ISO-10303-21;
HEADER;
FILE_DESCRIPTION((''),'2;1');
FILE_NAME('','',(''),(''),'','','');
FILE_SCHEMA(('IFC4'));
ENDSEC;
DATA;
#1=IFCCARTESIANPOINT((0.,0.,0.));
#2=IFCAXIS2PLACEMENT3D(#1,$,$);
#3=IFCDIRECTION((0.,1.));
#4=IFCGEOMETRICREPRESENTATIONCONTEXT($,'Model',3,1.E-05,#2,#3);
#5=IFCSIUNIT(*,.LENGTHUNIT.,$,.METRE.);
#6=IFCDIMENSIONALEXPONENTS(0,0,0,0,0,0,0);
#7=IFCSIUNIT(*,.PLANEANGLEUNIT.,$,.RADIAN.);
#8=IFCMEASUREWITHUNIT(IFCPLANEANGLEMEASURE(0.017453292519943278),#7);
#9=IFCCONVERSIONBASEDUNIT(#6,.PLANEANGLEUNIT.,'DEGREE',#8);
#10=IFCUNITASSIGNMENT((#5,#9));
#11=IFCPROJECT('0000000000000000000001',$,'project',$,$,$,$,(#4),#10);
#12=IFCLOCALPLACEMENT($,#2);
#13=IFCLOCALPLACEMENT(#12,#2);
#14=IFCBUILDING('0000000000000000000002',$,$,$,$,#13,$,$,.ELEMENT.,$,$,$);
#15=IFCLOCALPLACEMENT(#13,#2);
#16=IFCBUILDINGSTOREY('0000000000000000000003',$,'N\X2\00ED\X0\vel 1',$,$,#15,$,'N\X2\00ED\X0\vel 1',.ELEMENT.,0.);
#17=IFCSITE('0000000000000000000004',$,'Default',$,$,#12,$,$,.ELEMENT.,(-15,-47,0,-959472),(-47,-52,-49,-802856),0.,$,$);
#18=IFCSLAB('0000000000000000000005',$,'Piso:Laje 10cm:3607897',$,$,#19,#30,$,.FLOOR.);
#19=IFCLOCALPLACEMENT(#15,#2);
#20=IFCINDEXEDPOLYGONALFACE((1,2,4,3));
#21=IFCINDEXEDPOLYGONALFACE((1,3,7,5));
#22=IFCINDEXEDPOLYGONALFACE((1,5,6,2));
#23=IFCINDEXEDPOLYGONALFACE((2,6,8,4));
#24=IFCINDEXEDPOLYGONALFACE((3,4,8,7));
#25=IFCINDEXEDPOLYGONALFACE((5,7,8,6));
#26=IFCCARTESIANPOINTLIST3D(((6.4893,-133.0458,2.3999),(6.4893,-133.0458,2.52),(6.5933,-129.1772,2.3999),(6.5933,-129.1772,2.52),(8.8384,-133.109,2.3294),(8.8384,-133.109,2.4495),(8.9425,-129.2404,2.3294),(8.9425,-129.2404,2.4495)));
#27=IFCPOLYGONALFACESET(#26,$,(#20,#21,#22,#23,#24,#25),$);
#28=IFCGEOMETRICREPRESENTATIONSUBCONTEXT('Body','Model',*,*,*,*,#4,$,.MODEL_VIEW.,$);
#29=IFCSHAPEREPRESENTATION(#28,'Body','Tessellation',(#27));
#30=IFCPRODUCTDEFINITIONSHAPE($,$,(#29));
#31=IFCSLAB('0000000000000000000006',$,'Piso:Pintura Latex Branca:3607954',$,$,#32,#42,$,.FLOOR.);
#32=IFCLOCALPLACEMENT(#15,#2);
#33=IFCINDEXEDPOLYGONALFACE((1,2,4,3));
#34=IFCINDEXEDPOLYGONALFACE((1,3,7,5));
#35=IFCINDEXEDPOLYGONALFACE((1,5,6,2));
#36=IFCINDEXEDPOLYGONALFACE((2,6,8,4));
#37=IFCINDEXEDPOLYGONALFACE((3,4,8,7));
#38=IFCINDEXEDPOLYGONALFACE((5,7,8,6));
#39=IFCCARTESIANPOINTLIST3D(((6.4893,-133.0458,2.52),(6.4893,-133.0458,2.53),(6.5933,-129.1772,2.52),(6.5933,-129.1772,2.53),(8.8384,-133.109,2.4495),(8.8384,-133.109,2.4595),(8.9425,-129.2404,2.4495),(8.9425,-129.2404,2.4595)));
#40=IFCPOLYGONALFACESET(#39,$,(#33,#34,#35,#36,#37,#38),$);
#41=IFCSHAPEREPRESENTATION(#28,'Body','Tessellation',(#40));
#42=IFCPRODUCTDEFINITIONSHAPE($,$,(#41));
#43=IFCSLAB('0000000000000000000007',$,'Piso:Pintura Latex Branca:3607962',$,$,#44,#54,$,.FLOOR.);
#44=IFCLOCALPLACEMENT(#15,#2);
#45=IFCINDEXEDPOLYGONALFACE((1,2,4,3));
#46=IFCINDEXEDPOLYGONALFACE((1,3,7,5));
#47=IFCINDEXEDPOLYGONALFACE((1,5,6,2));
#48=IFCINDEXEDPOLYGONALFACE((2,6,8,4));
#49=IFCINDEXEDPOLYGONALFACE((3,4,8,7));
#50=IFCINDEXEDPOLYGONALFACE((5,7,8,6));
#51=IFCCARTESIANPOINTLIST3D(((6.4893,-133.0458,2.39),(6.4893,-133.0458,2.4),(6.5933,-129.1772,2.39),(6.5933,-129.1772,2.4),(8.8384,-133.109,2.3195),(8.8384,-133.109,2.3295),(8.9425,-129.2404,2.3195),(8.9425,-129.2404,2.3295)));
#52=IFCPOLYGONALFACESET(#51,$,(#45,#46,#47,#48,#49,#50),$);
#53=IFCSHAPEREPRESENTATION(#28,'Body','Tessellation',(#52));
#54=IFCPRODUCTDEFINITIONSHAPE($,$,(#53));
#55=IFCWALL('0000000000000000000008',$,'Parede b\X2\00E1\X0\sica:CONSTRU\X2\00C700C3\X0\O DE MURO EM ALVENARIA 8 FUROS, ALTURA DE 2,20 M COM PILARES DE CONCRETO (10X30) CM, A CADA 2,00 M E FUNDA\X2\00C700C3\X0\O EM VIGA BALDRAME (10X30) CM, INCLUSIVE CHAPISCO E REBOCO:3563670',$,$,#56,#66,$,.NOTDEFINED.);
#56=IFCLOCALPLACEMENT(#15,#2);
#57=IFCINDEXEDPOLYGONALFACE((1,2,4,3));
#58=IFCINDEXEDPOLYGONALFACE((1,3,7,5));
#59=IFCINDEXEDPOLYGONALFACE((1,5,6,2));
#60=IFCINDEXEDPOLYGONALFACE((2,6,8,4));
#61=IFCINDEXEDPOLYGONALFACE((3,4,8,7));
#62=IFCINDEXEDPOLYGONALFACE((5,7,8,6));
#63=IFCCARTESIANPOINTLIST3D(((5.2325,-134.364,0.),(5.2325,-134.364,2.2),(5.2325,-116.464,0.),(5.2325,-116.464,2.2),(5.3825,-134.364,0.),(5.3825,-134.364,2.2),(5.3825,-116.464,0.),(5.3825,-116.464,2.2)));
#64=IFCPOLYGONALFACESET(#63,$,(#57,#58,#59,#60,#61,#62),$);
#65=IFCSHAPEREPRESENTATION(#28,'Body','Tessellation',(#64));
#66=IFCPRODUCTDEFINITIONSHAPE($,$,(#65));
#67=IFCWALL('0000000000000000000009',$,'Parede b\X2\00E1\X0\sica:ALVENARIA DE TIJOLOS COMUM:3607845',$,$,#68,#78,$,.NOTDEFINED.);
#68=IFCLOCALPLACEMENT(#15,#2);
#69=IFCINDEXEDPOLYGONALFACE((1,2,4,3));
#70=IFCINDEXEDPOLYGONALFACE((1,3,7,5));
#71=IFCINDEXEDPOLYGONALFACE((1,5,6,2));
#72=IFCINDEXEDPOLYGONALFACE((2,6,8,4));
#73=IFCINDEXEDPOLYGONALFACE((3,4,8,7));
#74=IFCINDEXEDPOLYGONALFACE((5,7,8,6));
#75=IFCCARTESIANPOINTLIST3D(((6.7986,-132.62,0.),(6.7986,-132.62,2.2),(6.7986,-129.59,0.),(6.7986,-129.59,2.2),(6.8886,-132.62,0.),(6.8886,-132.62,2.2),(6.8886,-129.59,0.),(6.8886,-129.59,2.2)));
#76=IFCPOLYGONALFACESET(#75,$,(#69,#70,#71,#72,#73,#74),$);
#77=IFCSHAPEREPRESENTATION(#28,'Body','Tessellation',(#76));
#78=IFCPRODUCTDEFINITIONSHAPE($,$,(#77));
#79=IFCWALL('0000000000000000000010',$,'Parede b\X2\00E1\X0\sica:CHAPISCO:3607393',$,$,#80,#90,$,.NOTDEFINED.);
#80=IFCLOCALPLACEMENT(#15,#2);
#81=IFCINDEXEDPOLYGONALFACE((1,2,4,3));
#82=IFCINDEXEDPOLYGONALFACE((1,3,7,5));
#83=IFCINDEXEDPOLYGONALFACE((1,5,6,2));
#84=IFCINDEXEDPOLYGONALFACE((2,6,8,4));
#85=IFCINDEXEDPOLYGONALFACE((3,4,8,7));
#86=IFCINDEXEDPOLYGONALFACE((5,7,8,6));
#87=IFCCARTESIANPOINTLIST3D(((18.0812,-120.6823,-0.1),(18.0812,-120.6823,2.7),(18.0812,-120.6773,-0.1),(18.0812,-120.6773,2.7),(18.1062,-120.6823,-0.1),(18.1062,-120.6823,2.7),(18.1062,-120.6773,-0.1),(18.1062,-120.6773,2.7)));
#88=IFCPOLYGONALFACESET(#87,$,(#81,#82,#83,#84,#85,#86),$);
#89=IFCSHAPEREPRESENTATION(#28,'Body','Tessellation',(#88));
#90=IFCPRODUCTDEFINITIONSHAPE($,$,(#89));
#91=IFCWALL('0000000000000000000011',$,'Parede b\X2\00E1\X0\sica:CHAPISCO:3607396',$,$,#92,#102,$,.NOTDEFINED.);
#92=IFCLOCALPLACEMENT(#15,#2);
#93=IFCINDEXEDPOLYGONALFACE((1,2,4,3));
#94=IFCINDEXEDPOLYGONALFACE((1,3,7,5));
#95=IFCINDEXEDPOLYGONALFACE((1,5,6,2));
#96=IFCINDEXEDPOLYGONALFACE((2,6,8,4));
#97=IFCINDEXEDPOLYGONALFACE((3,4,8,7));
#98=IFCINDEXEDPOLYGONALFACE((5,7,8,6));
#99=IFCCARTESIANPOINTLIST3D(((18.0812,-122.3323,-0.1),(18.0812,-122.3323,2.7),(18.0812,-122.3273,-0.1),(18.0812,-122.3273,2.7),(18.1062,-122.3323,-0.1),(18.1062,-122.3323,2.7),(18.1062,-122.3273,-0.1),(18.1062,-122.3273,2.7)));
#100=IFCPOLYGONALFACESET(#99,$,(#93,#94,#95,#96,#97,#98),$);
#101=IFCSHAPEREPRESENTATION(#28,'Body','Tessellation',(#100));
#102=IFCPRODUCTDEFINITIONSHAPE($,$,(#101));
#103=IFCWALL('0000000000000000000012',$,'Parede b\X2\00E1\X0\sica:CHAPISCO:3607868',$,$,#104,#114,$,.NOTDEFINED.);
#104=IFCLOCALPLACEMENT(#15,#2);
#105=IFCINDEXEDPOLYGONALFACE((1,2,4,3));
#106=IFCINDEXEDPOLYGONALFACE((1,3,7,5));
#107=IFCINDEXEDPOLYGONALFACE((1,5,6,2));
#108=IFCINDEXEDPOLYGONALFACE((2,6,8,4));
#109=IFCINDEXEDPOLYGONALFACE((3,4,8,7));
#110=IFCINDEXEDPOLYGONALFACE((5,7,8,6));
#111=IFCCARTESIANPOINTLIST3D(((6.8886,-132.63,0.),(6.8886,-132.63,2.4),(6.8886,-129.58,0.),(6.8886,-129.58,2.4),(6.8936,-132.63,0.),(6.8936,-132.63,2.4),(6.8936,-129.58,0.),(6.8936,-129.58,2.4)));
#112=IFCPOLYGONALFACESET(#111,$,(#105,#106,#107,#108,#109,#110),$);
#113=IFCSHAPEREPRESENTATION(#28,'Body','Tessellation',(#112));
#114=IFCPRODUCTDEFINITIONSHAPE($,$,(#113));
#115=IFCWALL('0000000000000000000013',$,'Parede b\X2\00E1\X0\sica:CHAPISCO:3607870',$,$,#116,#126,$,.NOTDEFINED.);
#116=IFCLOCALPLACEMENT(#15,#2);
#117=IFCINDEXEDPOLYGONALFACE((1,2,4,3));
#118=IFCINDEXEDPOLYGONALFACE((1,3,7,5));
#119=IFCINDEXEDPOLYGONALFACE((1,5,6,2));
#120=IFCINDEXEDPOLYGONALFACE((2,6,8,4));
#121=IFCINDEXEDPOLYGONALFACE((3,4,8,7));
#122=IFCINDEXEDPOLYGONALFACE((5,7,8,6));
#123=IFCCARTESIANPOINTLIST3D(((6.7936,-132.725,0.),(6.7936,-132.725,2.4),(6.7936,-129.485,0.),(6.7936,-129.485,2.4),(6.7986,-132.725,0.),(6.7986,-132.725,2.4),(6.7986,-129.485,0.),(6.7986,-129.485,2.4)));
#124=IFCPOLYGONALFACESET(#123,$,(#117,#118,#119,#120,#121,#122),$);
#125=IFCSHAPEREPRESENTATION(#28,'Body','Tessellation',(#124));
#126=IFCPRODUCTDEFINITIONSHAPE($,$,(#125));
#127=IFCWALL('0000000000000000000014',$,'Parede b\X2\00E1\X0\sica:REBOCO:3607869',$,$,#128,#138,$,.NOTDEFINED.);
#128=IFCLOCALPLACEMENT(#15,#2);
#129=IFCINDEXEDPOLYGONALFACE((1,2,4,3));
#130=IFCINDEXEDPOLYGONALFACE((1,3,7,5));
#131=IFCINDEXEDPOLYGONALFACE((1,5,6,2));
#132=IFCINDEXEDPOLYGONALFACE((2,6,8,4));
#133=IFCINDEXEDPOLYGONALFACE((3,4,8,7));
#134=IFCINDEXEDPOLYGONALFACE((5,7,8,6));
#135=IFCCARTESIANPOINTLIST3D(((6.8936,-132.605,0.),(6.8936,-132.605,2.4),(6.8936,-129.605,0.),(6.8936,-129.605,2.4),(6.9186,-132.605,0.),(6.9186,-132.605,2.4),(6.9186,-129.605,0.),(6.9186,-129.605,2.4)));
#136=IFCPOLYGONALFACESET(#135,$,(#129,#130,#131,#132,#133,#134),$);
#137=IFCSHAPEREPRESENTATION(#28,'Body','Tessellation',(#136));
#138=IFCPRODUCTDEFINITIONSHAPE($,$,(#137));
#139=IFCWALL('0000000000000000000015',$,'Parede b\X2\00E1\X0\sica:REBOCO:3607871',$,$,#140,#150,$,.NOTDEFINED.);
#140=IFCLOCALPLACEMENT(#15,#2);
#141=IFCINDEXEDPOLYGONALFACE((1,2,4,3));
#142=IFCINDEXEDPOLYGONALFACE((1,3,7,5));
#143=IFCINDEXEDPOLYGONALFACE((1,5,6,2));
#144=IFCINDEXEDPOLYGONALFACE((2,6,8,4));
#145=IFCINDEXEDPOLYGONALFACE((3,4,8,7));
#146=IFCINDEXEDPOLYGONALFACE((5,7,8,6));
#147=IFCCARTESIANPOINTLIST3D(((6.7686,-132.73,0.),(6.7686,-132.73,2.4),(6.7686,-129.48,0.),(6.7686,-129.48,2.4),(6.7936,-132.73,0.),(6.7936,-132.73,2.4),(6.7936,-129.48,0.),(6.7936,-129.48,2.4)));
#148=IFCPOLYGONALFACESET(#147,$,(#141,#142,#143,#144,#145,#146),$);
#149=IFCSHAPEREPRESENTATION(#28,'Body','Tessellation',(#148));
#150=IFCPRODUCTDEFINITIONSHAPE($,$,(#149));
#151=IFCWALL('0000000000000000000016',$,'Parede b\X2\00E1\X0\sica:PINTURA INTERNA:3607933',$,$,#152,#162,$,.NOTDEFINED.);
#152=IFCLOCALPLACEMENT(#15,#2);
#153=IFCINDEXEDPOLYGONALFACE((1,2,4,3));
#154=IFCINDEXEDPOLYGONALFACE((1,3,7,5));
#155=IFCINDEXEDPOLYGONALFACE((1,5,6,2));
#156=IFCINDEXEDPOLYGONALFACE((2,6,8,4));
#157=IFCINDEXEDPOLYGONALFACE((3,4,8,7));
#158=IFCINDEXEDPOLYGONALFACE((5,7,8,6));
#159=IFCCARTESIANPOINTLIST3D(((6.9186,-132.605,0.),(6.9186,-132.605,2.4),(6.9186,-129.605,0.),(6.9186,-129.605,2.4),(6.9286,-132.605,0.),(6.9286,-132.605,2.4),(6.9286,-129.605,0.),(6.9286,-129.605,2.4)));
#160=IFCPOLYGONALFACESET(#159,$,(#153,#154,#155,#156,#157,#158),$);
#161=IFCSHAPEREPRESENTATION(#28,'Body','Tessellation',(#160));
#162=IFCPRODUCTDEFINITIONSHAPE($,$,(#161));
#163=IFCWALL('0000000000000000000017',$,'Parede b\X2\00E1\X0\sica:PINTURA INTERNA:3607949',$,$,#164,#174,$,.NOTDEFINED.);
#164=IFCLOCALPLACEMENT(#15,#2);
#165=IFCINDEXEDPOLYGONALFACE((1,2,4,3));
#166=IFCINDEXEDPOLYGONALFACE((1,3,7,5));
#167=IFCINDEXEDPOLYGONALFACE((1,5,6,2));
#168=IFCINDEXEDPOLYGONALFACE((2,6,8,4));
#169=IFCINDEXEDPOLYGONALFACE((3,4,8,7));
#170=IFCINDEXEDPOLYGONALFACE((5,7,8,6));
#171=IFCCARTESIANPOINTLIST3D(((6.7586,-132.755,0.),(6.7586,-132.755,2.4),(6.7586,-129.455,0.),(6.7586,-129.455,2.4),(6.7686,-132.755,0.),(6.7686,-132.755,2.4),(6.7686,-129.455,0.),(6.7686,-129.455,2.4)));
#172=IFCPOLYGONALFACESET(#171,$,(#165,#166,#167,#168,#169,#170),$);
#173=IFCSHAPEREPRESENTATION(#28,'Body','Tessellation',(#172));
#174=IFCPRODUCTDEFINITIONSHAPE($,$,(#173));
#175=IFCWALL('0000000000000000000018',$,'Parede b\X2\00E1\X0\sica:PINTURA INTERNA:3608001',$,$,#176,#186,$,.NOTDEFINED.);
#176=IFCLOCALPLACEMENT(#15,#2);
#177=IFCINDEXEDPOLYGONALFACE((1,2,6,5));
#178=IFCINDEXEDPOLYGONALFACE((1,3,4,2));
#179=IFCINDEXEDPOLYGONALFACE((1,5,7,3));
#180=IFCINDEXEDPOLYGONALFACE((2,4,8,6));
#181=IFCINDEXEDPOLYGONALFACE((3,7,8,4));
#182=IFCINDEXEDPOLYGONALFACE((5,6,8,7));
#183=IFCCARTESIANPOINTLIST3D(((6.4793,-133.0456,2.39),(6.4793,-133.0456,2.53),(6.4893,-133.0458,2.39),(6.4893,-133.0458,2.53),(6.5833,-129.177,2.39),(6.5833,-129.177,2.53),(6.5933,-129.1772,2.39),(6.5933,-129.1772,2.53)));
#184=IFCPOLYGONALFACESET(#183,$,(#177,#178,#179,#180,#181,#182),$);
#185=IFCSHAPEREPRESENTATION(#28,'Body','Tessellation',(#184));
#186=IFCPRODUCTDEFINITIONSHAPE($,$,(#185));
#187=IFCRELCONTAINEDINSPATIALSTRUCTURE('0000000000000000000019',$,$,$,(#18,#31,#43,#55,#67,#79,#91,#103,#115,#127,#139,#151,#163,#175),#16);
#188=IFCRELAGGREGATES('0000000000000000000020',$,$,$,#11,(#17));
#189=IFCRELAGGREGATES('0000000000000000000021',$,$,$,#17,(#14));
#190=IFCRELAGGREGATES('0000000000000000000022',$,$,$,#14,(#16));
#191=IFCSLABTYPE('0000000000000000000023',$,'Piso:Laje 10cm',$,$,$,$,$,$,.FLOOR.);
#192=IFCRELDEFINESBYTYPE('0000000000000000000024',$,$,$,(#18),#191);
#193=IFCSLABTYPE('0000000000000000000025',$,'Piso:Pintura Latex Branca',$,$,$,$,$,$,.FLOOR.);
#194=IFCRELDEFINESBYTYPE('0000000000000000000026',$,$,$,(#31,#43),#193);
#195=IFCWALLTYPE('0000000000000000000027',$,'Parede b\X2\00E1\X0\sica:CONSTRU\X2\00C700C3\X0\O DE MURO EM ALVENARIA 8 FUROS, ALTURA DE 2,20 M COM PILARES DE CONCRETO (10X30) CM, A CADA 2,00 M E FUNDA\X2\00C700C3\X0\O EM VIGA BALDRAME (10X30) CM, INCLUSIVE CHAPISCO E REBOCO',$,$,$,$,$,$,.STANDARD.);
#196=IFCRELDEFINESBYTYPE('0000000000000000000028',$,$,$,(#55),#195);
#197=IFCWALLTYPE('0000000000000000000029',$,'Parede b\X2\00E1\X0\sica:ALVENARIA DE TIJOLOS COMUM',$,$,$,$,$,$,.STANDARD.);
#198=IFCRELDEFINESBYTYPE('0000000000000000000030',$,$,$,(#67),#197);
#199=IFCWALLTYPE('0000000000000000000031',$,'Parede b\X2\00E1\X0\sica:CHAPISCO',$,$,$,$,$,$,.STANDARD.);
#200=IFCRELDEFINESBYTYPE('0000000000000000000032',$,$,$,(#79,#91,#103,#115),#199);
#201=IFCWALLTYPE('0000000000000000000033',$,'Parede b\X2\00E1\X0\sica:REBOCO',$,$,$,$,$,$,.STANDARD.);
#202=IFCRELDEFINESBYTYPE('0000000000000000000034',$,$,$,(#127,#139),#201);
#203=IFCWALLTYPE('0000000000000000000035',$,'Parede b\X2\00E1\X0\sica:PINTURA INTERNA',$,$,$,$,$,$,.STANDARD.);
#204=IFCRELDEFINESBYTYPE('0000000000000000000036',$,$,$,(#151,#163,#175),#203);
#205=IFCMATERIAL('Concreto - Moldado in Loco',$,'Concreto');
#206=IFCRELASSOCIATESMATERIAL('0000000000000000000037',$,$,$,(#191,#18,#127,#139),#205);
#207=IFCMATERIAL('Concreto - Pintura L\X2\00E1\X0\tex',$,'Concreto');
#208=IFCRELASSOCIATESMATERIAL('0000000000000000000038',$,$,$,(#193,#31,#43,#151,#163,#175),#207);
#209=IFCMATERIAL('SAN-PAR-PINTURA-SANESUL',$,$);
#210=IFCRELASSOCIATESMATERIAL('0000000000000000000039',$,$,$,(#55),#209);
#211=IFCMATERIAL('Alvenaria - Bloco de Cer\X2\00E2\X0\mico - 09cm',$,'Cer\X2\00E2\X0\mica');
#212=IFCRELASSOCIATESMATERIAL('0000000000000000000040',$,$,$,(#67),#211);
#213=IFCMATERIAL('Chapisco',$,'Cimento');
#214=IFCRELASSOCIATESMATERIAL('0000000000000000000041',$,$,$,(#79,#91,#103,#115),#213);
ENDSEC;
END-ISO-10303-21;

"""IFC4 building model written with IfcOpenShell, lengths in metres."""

from ifc_helpers import new_model, entity, si_unit, converted_unit, direction, frame, frame_2d, origin, place, context, subcontext, project, spatial, indexed_curve, rectangle, outline, extrude, material, type_object, element, save


model = new_model("IFC4")

# Units and contexts
model_context = context("Model", 3, precision=1e-05, world=origin(), true_north=direction((0.0, 1.0)))
body_context = subcontext(model_context, "Body", "Model", "MODEL_VIEW")
ifc_project = project(units=[si_unit("LENGTHUNIT", "METRE"), converted_unit("PLANEANGLEUNIT", "DEGREE", entity("IfcPlaneAngleMeasure", 0.017453292519943278), si_unit("PLANEANGLEUNIT", "RADIAN"), dimensions=[0, 0, 0, 0, 0, 0, 0])], contexts=[model_context])

# Site, building, storey
site_placement = place(None, origin())
site = spatial("IfcSite", under=ifc_project, at=site_placement, Name="Default", CompositionType="ELEMENT", RefLatitude=(-15, -47, 0, -959472), RefLongitude=(-47, -52, -49, -802856), RefElevation=0.0)
building_placement = place(site_placement, origin())
building = spatial("IfcBuilding", under=site, at=building_placement, CompositionType="ELEMENT")
storey_placement = place(building_placement, origin())
storey = spatial("IfcBuildingStorey", under=building, at=storey_placement, Name="Nível 1", LongName="Nível 1", CompositionType="ELEMENT", Elevation=0.0)

# Slabs
ifc_material_1 = material(Name="Concreto - Moldado in Loco", Category="Concreto")
slab_type_1 = type_object("IfcSlabType", Name="Piso:Laje 10cm", PredefinedType="FLOOR", material=ifc_material_1)
slab_placement = place(storey_placement, frame((6.4893, -133.109, 2.3294)))
element("IfcSlab", 1, at=slab_placement, inside=storey, type_object=slab_type_1, material=ifc_material_1, Name="Piso:Laje 10cm:3607897", PredefinedType="FLOOR", context=body_context, shape_type="SweptSolid", body=[
    extrude(rectangle(XDim=2.3511, YDim=3.87, at=frame_2d((1.2272, 1.9027), x_axis=(0.999638, -0.0269))), frame((0.0, 0.0632, 0.1906), z_axis=(0.029976, -0.000806, 0.99955), x_axis=(0.999551, 0.000024, -0.029976)), (0.029976, -0.000807, -0.99955), 0.1201),
])
ifc_material_2 = material(Name="Concreto - Pintura Látex", Category="Concreto")
slab_type_2 = type_object("IfcSlabType", Name="Piso:Pintura Latex Branca", PredefinedType="FLOOR", material=ifc_material_2)
for number, where, name in (
    (2, (6.4893, -133.109, 2.4495), "Piso:Pintura Latex Branca:3607954"),
    (3, (6.4893, -133.109, 2.3195), "Piso:Pintura Latex Branca:3607962"),
):
    element("IfcSlab", number, at=place(storey_placement, frame(where)), inside=storey, type_object=slab_type_2, material=ifc_material_2, Name=name, PredefinedType="FLOOR", context=body_context, shape_type="SweptSolid", body=[
        extrude(rectangle(XDim=2.3511, YDim=3.87, at=frame_2d((1.2272, 1.9027), x_axis=(0.999638, -0.0269))), frame((0.0, 0.0632, 0.0805), z_axis=(0.029976, -0.000806, 0.99955), x_axis=(0.999551, 0.000024, -0.029976)), (0.029976, -0.000807, -0.99955), 0.01),
    ])

# Walls
ifc_material_3 = material(Name="SAN-PAR-PINTURA-SANESUL")
wall_type_1 = type_object("IfcWallType", Name="Parede básica:CONSTRUÇÃO DE MURO EM ALVENARIA 8 FUROS, ALTURA DE 2,20 M COM PILARES DE CONCRETO (10X30) CM, A CADA 2,00 M E FUNDAÇÃO EM VIGA BALDRAME (10X30) CM, INCLUSIVE CHAPISCO E REBOCO", PredefinedType="STANDARD")
wall_1_placement = place(storey_placement, frame((5.3075, -134.364, 0.0), z_axis=(0.0, 0.0, 1.0), x_axis=(0.0, 1.0, 0.0)))
element("IfcWall", 4, at=wall_1_placement, inside=storey, type_object=wall_type_1, material=ifc_material_3, Name="Parede básica:CONSTRUÇÃO DE MURO EM ALVENARIA 8 FUROS, ALTURA DE 2,20 M COM PILARES DE CONCRETO (10X30) CM, A CADA 2,00 M E FUNDAÇÃO EM VIGA BALDRAME (10X30) CM, INCLUSIVE CHAPISCO E REBOCO:3563670", PredefinedType="NOTDEFINED", context=body_context, shape_type="SweptSolid", body=[
    extrude(outline(indexed_curve([(17.9, 0.075), (0.0, 0.075), (0.0, -0.075), (17.9, -0.075), (17.9, 0.075)], self_intersect=False)), origin(), (0.0, 0.0, 1.0), 2.2),
])
ifc_material_4 = material(Name="Alvenaria - Bloco de Cerâmico - 09cm", Category="Cerâmica")
wall_type_2 = type_object("IfcWallType", Name="Parede básica:ALVENARIA DE TIJOLOS COMUM", PredefinedType="STANDARD")
wall_2_placement = place(storey_placement, frame((6.8436, -132.62, 0.0), z_axis=(0.0, 0.0, 1.0), x_axis=(0.0, 1.0, 0.0)))
element("IfcWall", 5, at=wall_2_placement, inside=storey, type_object=wall_type_2, material=ifc_material_4, Name="Parede básica:ALVENARIA DE TIJOLOS COMUM:3607845", PredefinedType="NOTDEFINED", context=body_context, shape_type="SweptSolid", body=[
    extrude(outline(indexed_curve([(3.03, 0.045), (0.0, 0.045), (0.0, -0.045), (3.03, -0.045), (3.03, 0.045)], self_intersect=False)), origin(), (0.0, 0.0, 1.0), 2.2),
])
ifc_material_5 = material(Name="Chapisco", Category="Cimento")
wall_type_3 = type_object("IfcWallType", Name="Parede básica:CHAPISCO", PredefinedType="STANDARD")
wall_3_placement = place(storey_placement, frame((18.0812, -120.6798, -0.1)))
element("IfcWall", 6, at=wall_3_placement, inside=storey, type_object=wall_type_3, material=ifc_material_5, Name="Parede básica:CHAPISCO:3607393", PredefinedType="NOTDEFINED", context=body_context, shape_type="SweptSolid", body=[
    extrude(outline(indexed_curve([(0.025, 0.0025), (0.0, 0.0025), (0.0, -0.0025), (0.025, -0.0025), (0.025, 0.0025)], self_intersect=False)), origin(), (0.0, 0.0, 1.0), 2.8),
])
wall_4_placement = place(storey_placement, frame((18.0812, -122.3298, -0.1)))
element("IfcWall", 7, at=wall_4_placement, inside=storey, type_object=wall_type_3, material=ifc_material_5, Name="Parede básica:CHAPISCO:3607396", PredefinedType="NOTDEFINED", context=body_context, shape_type="SweptSolid", body=[
    extrude(outline(indexed_curve([(0.025, 0.0025), (0.0, 0.0025), (0.0, -0.0025), (0.025, -0.0025), (0.025, 0.0025)], self_intersect=False)), origin(), (0.0, 0.0, 1.0), 2.8),
])
wall_5_placement = place(storey_placement, frame((6.8911, -132.63, 0.0), z_axis=(0.0, 0.0, 1.0), x_axis=(0.0, 1.0, 0.0)))
element("IfcWall", 8, at=wall_5_placement, inside=storey, type_object=wall_type_3, material=ifc_material_5, Name="Parede básica:CHAPISCO:3607868", PredefinedType="NOTDEFINED", context=body_context, shape_type="SweptSolid", body=[
    extrude(outline(indexed_curve([(3.05, 0.0025), (0.0, 0.0025), (0.0, -0.0025), (3.05, -0.0025), (3.05, 0.0025)], self_intersect=False)), origin(), (0.0, 0.0, 1.0), 2.4),
])
wall_6_placement = place(storey_placement, frame((6.7961, -132.725, 0.0), z_axis=(0.0, 0.0, 1.0), x_axis=(0.0, 1.0, 0.0)))
element("IfcWall", 9, at=wall_6_placement, inside=storey, type_object=wall_type_3, material=ifc_material_5, Name="Parede básica:CHAPISCO:3607870", PredefinedType="NOTDEFINED", context=body_context, shape_type="SweptSolid", body=[
    extrude(outline(indexed_curve([(3.24, 0.0025), (0.0, 0.0025), (0.0, -0.0025), (3.24, -0.0025), (3.24, 0.0025)], self_intersect=False)), origin(), (0.0, 0.0, 1.0), 2.4),
])
wall_type_4 = type_object("IfcWallType", Name="Parede básica:REBOCO", PredefinedType="STANDARD")
wall_7_placement = place(storey_placement, frame((6.9061, -132.605, 0.0), z_axis=(0.0, 0.0, 1.0), x_axis=(0.0, 1.0, 0.0)))
element("IfcWall", 10, at=wall_7_placement, inside=storey, type_object=wall_type_4, material=ifc_material_1, Name="Parede básica:REBOCO:3607869", PredefinedType="NOTDEFINED", context=body_context, shape_type="SweptSolid", body=[
    extrude(outline(indexed_curve([(3.0, 0.0125), (0.0, 0.0125), (0.0, -0.0125), (3.0, -0.0125), (3.0, 0.0125)], self_intersect=False)), origin(), (0.0, 0.0, 1.0), 2.4),
])
wall_8_placement = place(storey_placement, frame((6.7811, -132.73, 0.0), z_axis=(0.0, 0.0, 1.0), x_axis=(0.0, 1.0, 0.0)))
element("IfcWall", 11, at=wall_8_placement, inside=storey, type_object=wall_type_4, material=ifc_material_1, Name="Parede básica:REBOCO:3607871", PredefinedType="NOTDEFINED", context=body_context, shape_type="SweptSolid", body=[
    extrude(outline(indexed_curve([(3.25, 0.0125), (0.0, 0.0125), (0.0, -0.0125), (3.25, -0.0125), (3.25, 0.0125)], self_intersect=False)), origin(), (0.0, 0.0, 1.0), 2.4),
])
wall_type_5 = type_object("IfcWallType", Name="Parede básica:PINTURA INTERNA", PredefinedType="STANDARD")
wall_9_placement = place(storey_placement, frame((6.9236, -132.605, 0.0), z_axis=(0.0, 0.0, 1.0), x_axis=(0.0, 1.0, 0.0)))
element("IfcWall", 12, at=wall_9_placement, inside=storey, type_object=wall_type_5, material=ifc_material_2, Name="Parede básica:PINTURA INTERNA:3607933", PredefinedType="NOTDEFINED", context=body_context, shape_type="SweptSolid", body=[
    extrude(outline(indexed_curve([(3.0, 0.005), (0.0, 0.005), (0.0, -0.005), (3.0, -0.005), (3.0, 0.005)], self_intersect=False)), origin(), (0.0, 0.0, 1.0), 2.4),
])
wall_10_placement = place(storey_placement, frame((6.7636, -129.455, 0.0), z_axis=(0.0, 0.0, 1.0), x_axis=(0.0, -1.0, 0.0)))
element("IfcWall", 13, at=wall_10_placement, inside=storey, type_object=wall_type_5, material=ifc_material_2, Name="Parede básica:PINTURA INTERNA:3607949", PredefinedType="NOTDEFINED", context=body_context, shape_type="SweptSolid", body=[
    extrude(outline(indexed_curve([(3.3, 0.005), (0.0, 0.005), (0.0, -0.005), (3.3, -0.005), (3.3, 0.005)], self_intersect=False)), origin(), (0.0, 0.0, 1.0), 2.4),
])
wall_11_placement = place(storey_placement, frame((6.5883, -129.1771, 2.39), z_axis=(0.0, 0.0, 1.0), x_axis=(-0.026888, -0.999638, 0.0)))
element("IfcWall", 14, at=wall_11_placement, inside=storey, type_object=wall_type_5, material=ifc_material_2, Name="Parede básica:PINTURA INTERNA:3608001", PredefinedType="NOTDEFINED", context=body_context, shape_type="SweptSolid", body=[
    extrude(outline(indexed_curve([(3.87, 0.005), (0.0, 0.005), (0.0, -0.005), (3.87, -0.005), (3.87, 0.005)], self_intersect=False)), origin(), (0.0, 0.0, 1.0), 0.14),
])

save(model, "model.ifc")
